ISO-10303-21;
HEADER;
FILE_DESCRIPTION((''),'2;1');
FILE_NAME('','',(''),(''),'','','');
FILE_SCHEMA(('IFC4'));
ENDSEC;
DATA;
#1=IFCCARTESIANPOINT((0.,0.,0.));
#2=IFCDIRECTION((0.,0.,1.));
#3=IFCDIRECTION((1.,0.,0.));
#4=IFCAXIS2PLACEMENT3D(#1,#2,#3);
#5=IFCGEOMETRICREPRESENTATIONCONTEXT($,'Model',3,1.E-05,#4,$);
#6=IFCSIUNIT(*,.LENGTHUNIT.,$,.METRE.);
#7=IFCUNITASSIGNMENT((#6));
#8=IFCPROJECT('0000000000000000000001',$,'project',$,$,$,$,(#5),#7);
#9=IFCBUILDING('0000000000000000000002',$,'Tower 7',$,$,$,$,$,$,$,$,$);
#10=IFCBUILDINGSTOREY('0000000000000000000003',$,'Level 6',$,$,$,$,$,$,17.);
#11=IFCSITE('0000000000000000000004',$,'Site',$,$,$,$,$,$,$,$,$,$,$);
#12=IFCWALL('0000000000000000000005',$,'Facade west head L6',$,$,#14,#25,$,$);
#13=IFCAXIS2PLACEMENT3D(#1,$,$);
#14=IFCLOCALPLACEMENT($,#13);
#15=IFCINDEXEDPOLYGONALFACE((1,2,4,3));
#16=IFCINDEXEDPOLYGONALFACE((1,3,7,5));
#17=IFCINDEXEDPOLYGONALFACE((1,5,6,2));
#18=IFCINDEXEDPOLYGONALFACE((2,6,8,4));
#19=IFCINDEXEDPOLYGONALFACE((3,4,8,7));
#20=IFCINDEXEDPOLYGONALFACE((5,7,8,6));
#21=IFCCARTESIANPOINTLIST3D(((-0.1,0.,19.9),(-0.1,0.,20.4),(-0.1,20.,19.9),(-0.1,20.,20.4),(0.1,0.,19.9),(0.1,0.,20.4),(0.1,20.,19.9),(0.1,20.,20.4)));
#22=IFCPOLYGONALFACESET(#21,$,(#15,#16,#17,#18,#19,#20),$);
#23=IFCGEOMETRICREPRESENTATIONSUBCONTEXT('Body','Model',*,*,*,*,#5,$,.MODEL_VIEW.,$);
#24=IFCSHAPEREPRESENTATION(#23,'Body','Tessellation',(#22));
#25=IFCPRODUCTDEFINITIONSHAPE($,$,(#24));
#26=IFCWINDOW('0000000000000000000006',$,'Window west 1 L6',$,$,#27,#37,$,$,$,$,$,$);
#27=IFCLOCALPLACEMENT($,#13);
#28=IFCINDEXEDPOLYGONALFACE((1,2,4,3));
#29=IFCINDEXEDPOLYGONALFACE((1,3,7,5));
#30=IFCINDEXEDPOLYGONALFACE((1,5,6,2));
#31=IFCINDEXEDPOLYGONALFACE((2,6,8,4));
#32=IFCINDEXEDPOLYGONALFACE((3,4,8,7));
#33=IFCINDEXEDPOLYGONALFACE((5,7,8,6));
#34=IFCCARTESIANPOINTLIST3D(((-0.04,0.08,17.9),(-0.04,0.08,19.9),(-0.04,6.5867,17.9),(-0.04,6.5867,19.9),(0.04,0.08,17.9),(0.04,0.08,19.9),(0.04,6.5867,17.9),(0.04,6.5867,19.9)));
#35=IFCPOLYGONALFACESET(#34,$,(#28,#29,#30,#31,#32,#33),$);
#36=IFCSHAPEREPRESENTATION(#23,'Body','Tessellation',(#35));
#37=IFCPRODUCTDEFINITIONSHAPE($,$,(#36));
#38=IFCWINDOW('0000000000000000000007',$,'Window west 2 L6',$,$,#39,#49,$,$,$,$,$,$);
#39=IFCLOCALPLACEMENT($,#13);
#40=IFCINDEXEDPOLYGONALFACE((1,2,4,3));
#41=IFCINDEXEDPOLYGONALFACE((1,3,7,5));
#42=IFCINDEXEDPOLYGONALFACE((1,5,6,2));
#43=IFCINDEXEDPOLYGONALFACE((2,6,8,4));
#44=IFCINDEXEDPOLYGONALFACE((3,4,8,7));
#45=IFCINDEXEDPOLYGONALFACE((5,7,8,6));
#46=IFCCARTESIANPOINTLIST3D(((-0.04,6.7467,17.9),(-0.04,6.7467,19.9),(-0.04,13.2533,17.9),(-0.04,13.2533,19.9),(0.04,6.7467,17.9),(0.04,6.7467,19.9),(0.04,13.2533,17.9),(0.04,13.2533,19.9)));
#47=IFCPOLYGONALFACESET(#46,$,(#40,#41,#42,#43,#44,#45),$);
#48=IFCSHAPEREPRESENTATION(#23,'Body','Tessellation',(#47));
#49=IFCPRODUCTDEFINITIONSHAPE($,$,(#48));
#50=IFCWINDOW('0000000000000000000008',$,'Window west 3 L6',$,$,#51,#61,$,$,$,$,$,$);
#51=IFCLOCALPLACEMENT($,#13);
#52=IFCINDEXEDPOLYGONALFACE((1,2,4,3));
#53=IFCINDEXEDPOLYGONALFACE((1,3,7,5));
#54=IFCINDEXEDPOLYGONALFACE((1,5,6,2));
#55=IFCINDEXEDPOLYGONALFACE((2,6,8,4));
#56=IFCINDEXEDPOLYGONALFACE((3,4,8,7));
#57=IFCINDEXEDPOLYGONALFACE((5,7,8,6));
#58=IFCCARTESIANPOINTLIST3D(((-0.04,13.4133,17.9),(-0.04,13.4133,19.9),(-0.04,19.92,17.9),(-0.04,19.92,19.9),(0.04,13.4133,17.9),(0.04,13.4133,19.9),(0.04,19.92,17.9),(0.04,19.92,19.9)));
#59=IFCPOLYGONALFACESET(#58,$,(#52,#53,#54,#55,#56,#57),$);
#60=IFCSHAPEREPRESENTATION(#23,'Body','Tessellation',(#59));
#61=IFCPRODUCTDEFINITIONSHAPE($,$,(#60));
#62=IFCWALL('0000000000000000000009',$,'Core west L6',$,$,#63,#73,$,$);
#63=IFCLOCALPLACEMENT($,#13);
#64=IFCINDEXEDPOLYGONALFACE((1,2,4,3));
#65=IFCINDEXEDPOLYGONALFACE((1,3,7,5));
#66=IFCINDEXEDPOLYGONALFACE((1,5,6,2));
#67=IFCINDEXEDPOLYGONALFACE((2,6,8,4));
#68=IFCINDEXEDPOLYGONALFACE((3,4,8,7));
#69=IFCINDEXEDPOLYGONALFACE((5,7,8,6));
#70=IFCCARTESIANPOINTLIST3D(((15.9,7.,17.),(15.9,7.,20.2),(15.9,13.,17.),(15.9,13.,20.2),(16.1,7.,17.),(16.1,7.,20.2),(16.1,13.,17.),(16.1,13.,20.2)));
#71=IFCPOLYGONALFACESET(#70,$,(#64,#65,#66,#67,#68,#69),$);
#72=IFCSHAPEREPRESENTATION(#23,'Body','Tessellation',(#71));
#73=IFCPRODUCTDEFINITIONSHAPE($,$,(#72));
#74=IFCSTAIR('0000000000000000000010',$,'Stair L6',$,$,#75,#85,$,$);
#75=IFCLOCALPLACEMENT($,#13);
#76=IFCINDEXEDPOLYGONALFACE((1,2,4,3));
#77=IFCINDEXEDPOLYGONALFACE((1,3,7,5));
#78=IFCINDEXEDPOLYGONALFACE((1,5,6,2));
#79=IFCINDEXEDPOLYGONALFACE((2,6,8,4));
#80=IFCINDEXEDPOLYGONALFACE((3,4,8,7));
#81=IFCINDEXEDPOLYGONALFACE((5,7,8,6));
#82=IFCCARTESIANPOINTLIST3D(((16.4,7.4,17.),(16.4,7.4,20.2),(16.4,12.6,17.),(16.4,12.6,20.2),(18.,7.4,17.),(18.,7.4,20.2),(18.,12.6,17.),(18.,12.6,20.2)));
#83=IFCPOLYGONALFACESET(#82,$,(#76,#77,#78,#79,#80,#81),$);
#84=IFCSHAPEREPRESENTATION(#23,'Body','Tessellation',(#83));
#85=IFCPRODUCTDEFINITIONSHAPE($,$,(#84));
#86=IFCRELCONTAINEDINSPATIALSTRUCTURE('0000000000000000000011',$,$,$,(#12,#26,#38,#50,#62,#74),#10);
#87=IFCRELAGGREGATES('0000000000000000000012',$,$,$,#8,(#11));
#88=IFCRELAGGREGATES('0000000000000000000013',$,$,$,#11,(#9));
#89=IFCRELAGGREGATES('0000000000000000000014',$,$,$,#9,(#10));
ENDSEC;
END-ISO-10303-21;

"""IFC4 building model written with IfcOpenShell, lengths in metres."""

from ifc_helpers import new_model, si_unit, frame, origin, origin_with_axes, origin_2d, place, context, subcontext, project, spatial, rectangle, extrude, element, save


model = new_model("IFC4")

# Units and contexts
model_context = context("Model", 3, precision=1e-05, world=origin_with_axes())
body_context = subcontext(model_context, "Body", "Model", "MODEL_VIEW")
ifc_project = project(units=[si_unit("LENGTHUNIT", "METRE")], contexts=[model_context])

# Site, building, storey
site = spatial("IfcSite", under=ifc_project, Name="Site")
building = spatial("IfcBuilding", under=site, Name="Tower 7")
storey = spatial("IfcBuildingStorey", under=building, Name="Level 6", Elevation=17.0)

# Wall
wall_1_placement = place(None, frame((0.0, 10.0, 19.9), z_axis=(0.0, 0.0, 1.0), x_axis=(1.0, 0.0, 0.0)))
element("IfcWall", 1, at=wall_1_placement, inside=storey, Name="Facade west head L6", context=body_context, shape_type="SweptSolid", body=[
    extrude(rectangle(XDim=0.2, YDim=20.0, at=origin_2d()), origin(), (0.0, 0.0, 1.0), 0.5),
])

# Windows
for number, where, z_axis, x_axis, name in (
    (2, (0.0, 3.3333, 17.9), (0.0, 0.0, 1.0), (1.0, 0.0, 0.0), "Window west 1 L6"),
    (3, (0.0, 10.0, 17.9), (0.0, 0.0, 1.0), (1.0, 0.0, 0.0), "Window west 2 L6"),
):
    element("IfcWindow", number, at=place(None, frame(where, z_axis=z_axis, x_axis=x_axis)), inside=storey, Name=name, context=body_context, shape_type="SweptSolid", body=[
        extrude(rectangle(XDim=0.08, YDim=6.5067, at=origin_2d()), origin(), (0.0, 0.0, 1.0), 2.0),
    ])
window_1_placement = place(None, frame((0.0, 16.6667, 17.9), z_axis=(0.0, 0.0, 1.0), x_axis=(1.0, 0.0, 0.0)))
element("IfcWindow", 4, at=window_1_placement, inside=storey, Name="Window west 3 L6", context=body_context, shape_type="SweptSolid", body=[
    extrude(rectangle(XDim=0.08, YDim=6.5067, at=origin_2d()), origin(), (0.0, 0.0, 1.0), 2.0),
])

# Wall
wall_2_placement = place(None, frame((16.0, 10.0, 17.0), z_axis=(0.0, 0.0, 1.0), x_axis=(1.0, 0.0, 0.0)))
element("IfcWall", 5, at=wall_2_placement, inside=storey, Name="Core west L6", context=body_context, shape_type="SweptSolid", body=[
    extrude(rectangle(XDim=0.2, YDim=6.0, at=origin_2d()), origin(), (0.0, 0.0, 1.0), 3.2),
])

# Stair
stair_placement = place(None, frame((17.2, 10.0, 17.0), z_axis=(0.0, 0.0, 1.0), x_axis=(1.0, 0.0, 0.0)))
element("IfcStair", 6, at=stair_placement, inside=storey, Name="Stair L6", context=body_context, shape_type="SweptSolid", body=[
    extrude(rectangle(XDim=1.6, YDim=5.2, at=origin_2d()), origin(), (0.0, 0.0, 1.0), 3.2),
])

save(model, "model.ifc")
